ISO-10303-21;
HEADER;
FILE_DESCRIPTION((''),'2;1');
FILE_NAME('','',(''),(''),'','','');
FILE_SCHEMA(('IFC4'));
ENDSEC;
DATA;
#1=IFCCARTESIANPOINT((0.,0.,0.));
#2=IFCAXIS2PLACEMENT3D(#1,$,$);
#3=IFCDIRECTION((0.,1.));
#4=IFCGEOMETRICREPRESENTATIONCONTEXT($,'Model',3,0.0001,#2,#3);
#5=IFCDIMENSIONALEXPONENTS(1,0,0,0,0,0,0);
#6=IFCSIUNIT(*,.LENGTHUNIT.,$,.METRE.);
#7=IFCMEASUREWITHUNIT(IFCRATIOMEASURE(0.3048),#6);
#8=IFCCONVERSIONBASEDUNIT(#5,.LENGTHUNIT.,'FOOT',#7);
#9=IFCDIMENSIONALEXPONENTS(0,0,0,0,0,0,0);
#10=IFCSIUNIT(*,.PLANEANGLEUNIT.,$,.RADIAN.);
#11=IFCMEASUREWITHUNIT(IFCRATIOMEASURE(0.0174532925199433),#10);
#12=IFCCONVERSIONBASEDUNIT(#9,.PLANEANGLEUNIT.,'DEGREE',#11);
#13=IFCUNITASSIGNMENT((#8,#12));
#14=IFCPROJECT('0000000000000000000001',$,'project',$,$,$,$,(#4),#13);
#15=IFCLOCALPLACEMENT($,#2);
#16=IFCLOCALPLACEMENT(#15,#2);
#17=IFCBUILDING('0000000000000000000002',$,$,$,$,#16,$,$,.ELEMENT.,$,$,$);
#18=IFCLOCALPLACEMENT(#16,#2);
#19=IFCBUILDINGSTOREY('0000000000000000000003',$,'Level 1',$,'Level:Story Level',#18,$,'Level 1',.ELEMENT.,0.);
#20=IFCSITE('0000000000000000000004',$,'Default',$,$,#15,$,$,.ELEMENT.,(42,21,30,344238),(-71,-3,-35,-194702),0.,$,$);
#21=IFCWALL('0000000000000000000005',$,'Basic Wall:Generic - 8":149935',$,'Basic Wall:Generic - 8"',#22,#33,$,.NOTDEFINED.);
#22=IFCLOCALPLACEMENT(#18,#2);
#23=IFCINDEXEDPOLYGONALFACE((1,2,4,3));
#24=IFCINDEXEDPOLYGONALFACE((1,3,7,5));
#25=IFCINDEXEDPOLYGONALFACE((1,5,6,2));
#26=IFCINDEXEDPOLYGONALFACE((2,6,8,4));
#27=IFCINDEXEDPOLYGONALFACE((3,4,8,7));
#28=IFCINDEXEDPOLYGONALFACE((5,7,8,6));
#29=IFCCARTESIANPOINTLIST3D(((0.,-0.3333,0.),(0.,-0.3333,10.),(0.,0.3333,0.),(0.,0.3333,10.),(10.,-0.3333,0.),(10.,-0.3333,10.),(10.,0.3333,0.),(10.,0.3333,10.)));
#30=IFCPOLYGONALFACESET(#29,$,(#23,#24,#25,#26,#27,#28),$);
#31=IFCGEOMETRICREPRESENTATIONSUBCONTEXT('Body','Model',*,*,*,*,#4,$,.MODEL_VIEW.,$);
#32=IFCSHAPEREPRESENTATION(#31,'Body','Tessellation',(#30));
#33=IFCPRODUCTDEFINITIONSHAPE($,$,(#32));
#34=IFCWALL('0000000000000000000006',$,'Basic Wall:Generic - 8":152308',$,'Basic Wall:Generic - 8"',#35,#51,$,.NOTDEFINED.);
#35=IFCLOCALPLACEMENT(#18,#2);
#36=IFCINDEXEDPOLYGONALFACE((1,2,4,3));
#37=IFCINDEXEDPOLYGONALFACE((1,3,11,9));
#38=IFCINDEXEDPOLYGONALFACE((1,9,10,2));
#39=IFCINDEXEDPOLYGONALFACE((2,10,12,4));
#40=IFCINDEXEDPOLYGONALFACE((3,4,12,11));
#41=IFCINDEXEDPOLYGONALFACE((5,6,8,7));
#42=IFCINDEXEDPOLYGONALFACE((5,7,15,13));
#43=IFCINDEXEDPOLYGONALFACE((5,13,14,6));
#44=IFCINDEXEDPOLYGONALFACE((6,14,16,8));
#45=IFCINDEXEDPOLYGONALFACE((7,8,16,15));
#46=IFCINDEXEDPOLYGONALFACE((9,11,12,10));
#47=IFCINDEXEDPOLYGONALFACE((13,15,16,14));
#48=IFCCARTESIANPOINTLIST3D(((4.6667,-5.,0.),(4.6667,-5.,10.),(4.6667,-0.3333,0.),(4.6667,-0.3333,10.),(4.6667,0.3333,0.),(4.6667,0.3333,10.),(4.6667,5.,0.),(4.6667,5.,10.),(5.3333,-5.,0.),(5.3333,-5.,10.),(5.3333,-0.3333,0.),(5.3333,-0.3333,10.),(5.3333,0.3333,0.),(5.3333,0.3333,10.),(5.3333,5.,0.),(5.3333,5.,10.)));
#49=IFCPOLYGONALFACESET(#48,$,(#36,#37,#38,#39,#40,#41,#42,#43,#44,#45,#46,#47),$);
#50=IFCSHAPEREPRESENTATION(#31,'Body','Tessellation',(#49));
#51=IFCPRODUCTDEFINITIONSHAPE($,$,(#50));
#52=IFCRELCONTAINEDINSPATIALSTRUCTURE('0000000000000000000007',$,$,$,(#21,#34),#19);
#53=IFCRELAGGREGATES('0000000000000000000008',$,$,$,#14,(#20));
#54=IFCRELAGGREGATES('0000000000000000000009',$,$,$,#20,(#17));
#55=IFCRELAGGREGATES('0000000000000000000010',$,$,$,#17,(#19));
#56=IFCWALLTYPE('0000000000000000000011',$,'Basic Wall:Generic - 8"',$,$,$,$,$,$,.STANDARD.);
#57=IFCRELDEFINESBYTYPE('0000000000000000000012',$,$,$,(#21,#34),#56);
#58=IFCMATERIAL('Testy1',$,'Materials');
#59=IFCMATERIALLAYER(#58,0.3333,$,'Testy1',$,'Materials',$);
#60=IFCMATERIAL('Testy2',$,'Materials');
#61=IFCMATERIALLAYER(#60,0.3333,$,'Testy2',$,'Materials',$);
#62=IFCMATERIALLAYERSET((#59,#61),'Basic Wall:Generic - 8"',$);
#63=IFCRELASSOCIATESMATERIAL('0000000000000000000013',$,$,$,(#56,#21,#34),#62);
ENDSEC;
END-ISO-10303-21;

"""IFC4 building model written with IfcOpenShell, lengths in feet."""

from ifc_helpers import new_model, entity, si_unit, converted_unit, direction, frame, frame_2d, origin, place, context, subcontext, project, spatial, rectangle, extrude, material, layer, layer_set, layer_usage, type_object, element, save


model = new_model("IFC4")

# Units and contexts
model_context = context("Model", 3, precision=0.0001, world=origin(), true_north=direction((0.0, 1.0)))
body_context = subcontext(model_context, "Body", "Model", "MODEL_VIEW")
ifc_project = project(units=[converted_unit("LENGTHUNIT", "FOOT", entity("IfcRatioMeasure", 0.3048), si_unit("LENGTHUNIT", "METRE"), dimensions=[1, 0, 0, 0, 0, 0, 0]), converted_unit("PLANEANGLEUNIT", "DEGREE", entity("IfcRatioMeasure", 0.0174532925199433), si_unit("PLANEANGLEUNIT", "RADIAN"), dimensions=[0, 0, 0, 0, 0, 0, 0])], contexts=[model_context])

# Site, building, storey
site_placement = place(None, origin())
site = spatial("IfcSite", under=ifc_project, at=site_placement, Name="Default", CompositionType="ELEMENT", RefLatitude=(42, 21, 30, 344238), RefLongitude=(-71, -3, -35, -194702), RefElevation=0.0)
building_placement = place(site_placement, origin())
building = spatial("IfcBuilding", under=site, at=building_placement, CompositionType="ELEMENT")
storey_placement = place(building_placement, origin())
storey = spatial("IfcBuildingStorey", under=building, at=storey_placement, Name="Level 1", ObjectType="Level:Story Level", LongName="Level 1", CompositionType="ELEMENT", Elevation=0.0)

# Wall
ifc_material_1 = material(Name="Testy1", Category="Materials")
ifc_layer_1 = layer(ifc_material_1, 0.3333, Name="Testy1", Category="Materials")
ifc_material_2 = material(Name="Testy2", Category="Materials")
ifc_layer_2 = layer(ifc_material_2, 0.3333, Name="Testy2", Category="Materials")
ifc_layer_set = layer_set([ifc_layer_1, ifc_layer_2], Name="Basic Wall:Generic - 8\"")
ifc_layer_usage_1 = layer_usage(ifc_layer_set, "AXIS2", "NEGATIVE", 0.3333)
wall_type = type_object("IfcWallType", Name="Basic Wall:Generic - 8\"", PredefinedType="STANDARD", material=ifc_layer_set)
wall_1_placement = place(storey_placement, origin())
element("IfcWall", 1, at=wall_1_placement, inside=storey, type_object=wall_type, material=ifc_layer_usage_1, Name="Basic Wall:Generic - 8\":149935", ObjectType="Basic Wall:Generic - 8\"", PredefinedType="NOTDEFINED", context=body_context, shape_type="SweptSolid", body=[
    extrude(rectangle(XDim=10.0, YDim=0.6667, at=frame_2d((5.0, 0.0), x_axis=(-1.0, 0.0))), origin(), (0.0, 0.0, 1.0), 10.0),
])

# Wall, opening
ifc_layer_usage_2 = layer_usage(ifc_layer_set, "AXIS2", "NEGATIVE", 0.3333)
wall_2_placement = place(storey_placement, frame((5.0, -5.0, 0.0), z_axis=(0.0, 0.0, 1.0), x_axis=(0.0, 1.0, 0.0)))
wall_2 = element("IfcWall", 2, at=wall_2_placement, inside=storey, type_object=wall_type, material=ifc_layer_usage_2, Name="Basic Wall:Generic - 8\":152308", ObjectType="Basic Wall:Generic - 8\"", PredefinedType="NOTDEFINED", context=body_context, shape_type="SweptSolid", body=[
    extrude(rectangle(XDim=10.0, YDim=0.6667, at=frame_2d((5.0, 0.0), x_axis=(-1.0, 0.0))), origin(), (0.0, 0.0, 1.0), 10.0),
])
opening_placement = place(storey_placement, frame((5.0, -5.0, 0.0), z_axis=(0.0, 0.0, 1.0), x_axis=(0.0, 1.0, 0.0)))
element("IfcOpeningElement", 3, at=opening_placement, cuts=wall_2, PredefinedType="OPENING", context=body_context, shape_type="SweptSolid", body=[
    extrude(rectangle(XDim=10.0, YDim=0.6667, at=frame_2d((0.0, 0.0), x_axis=(1.0, 0.0))), frame((4.6667, 0.0, 5.0), z_axis=(1.0, 0.0, 0.0), x_axis=(0.0, 0.0, -1.0)), (0.0, 0.0, 1.0), 0.6667),
])

save(model, "model.ifc")
